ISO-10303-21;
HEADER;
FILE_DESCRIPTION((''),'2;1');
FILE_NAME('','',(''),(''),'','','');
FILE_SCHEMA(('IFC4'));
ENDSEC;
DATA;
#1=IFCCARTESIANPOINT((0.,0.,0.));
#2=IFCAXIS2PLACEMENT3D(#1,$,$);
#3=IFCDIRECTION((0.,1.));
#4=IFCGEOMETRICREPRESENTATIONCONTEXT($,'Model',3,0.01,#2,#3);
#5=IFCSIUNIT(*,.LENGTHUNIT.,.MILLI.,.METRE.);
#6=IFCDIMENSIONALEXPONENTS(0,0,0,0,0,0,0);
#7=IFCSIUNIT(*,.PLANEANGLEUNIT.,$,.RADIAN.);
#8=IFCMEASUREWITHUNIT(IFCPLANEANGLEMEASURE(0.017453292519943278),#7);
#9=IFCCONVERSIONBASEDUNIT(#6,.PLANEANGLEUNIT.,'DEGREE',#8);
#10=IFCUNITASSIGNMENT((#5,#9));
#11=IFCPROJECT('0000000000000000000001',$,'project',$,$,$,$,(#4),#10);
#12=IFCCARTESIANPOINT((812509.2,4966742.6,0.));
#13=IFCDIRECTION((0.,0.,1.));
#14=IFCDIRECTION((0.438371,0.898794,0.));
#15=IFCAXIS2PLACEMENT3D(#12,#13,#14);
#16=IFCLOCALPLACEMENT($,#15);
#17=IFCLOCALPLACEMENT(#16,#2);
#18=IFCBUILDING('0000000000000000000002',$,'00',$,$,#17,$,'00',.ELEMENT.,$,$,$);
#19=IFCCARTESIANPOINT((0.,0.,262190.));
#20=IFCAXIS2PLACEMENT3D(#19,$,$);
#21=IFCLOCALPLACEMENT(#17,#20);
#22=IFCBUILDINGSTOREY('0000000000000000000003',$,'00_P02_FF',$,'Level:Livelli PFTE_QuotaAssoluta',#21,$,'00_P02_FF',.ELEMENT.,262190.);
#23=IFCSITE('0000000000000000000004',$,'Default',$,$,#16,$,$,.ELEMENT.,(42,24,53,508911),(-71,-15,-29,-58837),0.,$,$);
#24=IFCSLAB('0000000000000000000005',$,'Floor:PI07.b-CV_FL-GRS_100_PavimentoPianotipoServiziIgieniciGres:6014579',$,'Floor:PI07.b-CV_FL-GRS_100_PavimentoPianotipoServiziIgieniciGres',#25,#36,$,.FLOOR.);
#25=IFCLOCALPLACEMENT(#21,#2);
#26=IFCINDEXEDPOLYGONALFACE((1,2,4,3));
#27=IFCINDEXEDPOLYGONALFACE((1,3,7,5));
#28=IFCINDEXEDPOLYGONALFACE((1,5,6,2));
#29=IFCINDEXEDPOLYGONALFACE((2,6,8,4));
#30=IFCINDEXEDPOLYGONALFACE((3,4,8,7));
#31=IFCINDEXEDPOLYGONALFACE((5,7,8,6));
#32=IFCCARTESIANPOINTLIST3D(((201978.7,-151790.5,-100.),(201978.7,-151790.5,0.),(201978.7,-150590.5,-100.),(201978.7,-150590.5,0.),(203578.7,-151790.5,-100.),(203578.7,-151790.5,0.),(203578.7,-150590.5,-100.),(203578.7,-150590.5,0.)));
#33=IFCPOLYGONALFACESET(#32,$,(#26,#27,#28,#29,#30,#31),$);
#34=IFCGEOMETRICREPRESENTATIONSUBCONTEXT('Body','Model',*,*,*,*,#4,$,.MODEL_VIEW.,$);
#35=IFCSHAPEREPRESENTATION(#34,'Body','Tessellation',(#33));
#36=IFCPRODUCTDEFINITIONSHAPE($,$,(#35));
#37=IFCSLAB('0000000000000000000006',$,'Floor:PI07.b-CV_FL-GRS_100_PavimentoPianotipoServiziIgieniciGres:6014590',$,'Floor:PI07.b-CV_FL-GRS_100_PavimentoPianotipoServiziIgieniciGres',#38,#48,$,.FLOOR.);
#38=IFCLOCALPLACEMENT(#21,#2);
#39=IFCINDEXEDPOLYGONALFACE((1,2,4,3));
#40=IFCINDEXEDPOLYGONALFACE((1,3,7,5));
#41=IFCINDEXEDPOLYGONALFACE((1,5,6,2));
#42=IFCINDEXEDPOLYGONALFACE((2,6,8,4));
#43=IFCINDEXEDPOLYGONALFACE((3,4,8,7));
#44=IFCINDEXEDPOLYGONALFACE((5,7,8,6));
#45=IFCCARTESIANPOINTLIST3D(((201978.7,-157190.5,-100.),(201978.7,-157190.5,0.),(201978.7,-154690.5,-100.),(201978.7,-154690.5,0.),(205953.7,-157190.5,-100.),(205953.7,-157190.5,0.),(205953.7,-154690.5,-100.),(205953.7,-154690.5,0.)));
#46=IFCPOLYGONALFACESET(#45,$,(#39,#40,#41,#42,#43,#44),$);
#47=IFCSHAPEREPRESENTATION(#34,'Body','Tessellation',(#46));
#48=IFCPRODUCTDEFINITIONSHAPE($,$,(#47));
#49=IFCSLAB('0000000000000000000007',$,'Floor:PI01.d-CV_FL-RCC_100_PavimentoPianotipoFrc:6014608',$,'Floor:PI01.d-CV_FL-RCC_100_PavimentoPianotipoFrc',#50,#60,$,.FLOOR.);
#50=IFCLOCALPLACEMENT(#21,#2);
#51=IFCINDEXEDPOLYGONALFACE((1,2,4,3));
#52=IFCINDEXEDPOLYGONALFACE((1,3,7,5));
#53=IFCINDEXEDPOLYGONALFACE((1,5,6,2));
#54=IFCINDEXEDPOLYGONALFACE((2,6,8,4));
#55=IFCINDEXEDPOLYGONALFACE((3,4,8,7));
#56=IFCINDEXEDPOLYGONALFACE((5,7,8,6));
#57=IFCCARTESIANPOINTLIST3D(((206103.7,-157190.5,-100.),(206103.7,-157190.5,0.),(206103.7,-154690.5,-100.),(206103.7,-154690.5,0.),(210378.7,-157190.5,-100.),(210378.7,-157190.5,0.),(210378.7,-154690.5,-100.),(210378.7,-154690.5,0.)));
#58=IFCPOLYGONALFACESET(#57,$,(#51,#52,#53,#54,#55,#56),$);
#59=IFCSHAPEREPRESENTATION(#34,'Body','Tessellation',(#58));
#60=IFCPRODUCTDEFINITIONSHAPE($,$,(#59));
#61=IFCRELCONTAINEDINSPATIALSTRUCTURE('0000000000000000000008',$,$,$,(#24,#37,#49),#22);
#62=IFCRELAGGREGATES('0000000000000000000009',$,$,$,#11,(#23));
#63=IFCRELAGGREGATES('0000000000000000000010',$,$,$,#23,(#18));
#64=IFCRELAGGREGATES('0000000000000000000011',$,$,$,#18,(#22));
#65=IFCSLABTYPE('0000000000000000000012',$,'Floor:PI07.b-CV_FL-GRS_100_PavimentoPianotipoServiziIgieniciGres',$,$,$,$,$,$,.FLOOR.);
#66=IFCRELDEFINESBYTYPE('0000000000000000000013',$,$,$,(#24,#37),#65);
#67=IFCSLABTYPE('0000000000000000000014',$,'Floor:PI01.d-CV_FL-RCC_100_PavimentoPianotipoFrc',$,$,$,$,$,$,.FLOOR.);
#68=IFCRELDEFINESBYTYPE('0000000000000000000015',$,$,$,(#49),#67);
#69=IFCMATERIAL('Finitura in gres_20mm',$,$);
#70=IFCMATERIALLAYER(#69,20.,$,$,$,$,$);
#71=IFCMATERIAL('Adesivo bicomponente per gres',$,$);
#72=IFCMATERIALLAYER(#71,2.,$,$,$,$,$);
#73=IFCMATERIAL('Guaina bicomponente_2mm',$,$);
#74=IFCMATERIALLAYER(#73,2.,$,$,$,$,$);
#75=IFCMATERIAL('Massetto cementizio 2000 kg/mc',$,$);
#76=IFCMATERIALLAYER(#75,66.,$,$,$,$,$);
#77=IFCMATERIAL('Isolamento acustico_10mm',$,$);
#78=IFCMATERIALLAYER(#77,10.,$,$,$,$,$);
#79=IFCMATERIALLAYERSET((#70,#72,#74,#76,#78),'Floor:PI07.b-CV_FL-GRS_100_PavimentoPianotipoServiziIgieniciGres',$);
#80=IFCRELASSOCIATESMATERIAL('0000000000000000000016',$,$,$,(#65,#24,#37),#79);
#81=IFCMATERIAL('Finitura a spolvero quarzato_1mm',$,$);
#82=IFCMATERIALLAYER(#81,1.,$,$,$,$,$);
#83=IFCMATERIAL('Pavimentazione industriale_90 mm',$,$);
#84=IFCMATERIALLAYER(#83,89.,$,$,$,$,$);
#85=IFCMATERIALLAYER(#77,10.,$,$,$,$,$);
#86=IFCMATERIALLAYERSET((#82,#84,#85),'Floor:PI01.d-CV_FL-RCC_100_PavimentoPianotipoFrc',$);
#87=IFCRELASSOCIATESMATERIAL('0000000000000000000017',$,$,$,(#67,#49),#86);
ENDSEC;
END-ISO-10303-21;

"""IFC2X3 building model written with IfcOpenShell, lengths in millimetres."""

from ifc_helpers import new_model, entity, si_unit, converted_unit, direction, frame, frame_2d, origin, origin_2d_with_axis, place, context, subcontext, project, spatial, rectangle, extrude, material, layer, layer_set, layer_usage, type_object, element, save


model = new_model("IFC2X3")

# Units and contexts
model_context = context("Model", 3, precision=0.01, world=origin(), true_north=direction((0.0, 1.0)))
body_context = subcontext(model_context, "Body", "Model", "MODEL_VIEW")
ifc_project = project(units=[si_unit("LENGTHUNIT", "METRE", prefix="MILLI"), converted_unit("PLANEANGLEUNIT", "DEGREE", entity("IfcPlaneAngleMeasure", 0.017453292519943278), si_unit("PLANEANGLEUNIT", "RADIAN"), dimensions=[0, 0, 0, 0, 0, 0, 0])], contexts=[model_context])

# Site, building, storey
site_placement = place(None, frame((812509.2, 4966742.6, 0.0), z_axis=(0.0, 0.0, 1.0), x_axis=(0.438371, 0.898794, 0.0)))
site = spatial("IfcSite", under=ifc_project, at=site_placement, Name="Default", CompositionType="ELEMENT", RefLatitude=(42, 24, 53, 508911), RefLongitude=(-71, -15, -29, -58837), RefElevation=0.0)
building_placement = place(site_placement, origin())
building = spatial("IfcBuilding", under=site, at=building_placement, Name="00", LongName="00", CompositionType="ELEMENT")
storey_placement = place(building_placement, frame((0.0, 0.0, 262190.0)))
storey = spatial("IfcBuildingStorey", under=building, at=storey_placement, Name="00_P02_FF", ObjectType="Level:Livelli PFTE_QuotaAssoluta", LongName="00_P02_FF", CompositionType="ELEMENT", Elevation=262190.0)

# Slabs
ifc_material_1 = material(Name="Massetto cementizio 2000 kg/mc")
ifc_material_2 = material(Name="Isolamento acustico_10mm")
ifc_material_3 = material(Name="Finitura in gres_20mm")
ifc_layer_1 = layer(ifc_material_3, 20.0)
ifc_material_4 = material(Name="Adesivo bicomponente per gres")
ifc_layer_2 = layer(ifc_material_4, 2.0)
ifc_material_5 = material(Name="Guaina bicomponente_2mm")
ifc_layer_3 = layer(ifc_material_5, 2.0)
ifc_layer_4 = layer(ifc_material_1, 66.0)
ifc_layer_5 = layer(ifc_material_2, 10.0)
ifc_layer_set_1 = layer_set([ifc_layer_1, ifc_layer_2, ifc_layer_3, ifc_layer_4, ifc_layer_5], Name="Floor:PI07.b-CV_FL-GRS_100_PavimentoPianotipoServiziIgieniciGres")
ifc_layer_usage_1 = layer_usage(ifc_layer_set_1, "AXIS3", "POSITIVE", 0.0)
slab_type_1 = type_object("IfcSlabType", Name="Floor:PI07.b-CV_FL-GRS_100_PavimentoPianotipoServiziIgieniciGres", PredefinedType="FLOOR", material=ifc_layer_set_1)
slab_1_placement = place(storey_placement, origin())
element("IfcSlab", 1, at=slab_1_placement, inside=storey, type_object=slab_type_1, material=ifc_layer_usage_1, Name="Floor:PI07.b-CV_FL-GRS_100_PavimentoPianotipoServiziIgieniciGres:6014579", ObjectType="Floor:PI07.b-CV_FL-GRS_100_PavimentoPianotipoServiziIgieniciGres", PredefinedType="FLOOR", context=body_context, shape_type="SweptSolid", body=[
    extrude(rectangle(XDim=1200.0, YDim=1600.0, at=origin_2d_with_axis()), frame((202778.7, -151190.5, 0.0), z_axis=(0.0, 0.0, -1.0), x_axis=(0.0, 1.0, 0.0)), (0.0, 0.0, 1.0), 100.0),
])
ifc_layer_usage_2 = layer_usage(ifc_layer_set_1, "AXIS3", "POSITIVE", 0.0)
slab_2_placement = place(storey_placement, origin())
element("IfcSlab", 2, at=slab_2_placement, inside=storey, type_object=slab_type_1, material=ifc_layer_usage_2, Name="Floor:PI07.b-CV_FL-GRS_100_PavimentoPianotipoServiziIgieniciGres:6014590", ObjectType="Floor:PI07.b-CV_FL-GRS_100_PavimentoPianotipoServiziIgieniciGres", PredefinedType="FLOOR", context=body_context, shape_type="SweptSolid", body=[
    extrude(rectangle(XDim=2500.0, YDim=3975.0, at=frame_2d((0.0, 0.0), x_axis=(1.0, 0.0))), frame((203966.2, -155940.5, 0.0), z_axis=(0.0, 0.0, -1.0), x_axis=(0.0, 1.0, 0.0)), (0.0, 0.0, 1.0), 100.0),
])
ifc_material_6 = material(Name="Finitura a spolvero quarzato_1mm")
ifc_layer_6 = layer(ifc_material_6, 1.0)
ifc_material_7 = material(Name="Pavimentazione industriale_90 mm")
ifc_layer_7 = layer(ifc_material_7, 89.0)
ifc_layer_8 = layer(ifc_material_2, 10.0)
ifc_layer_set_2 = layer_set([ifc_layer_6, ifc_layer_7, ifc_layer_8], Name="Floor:PI01.d-CV_FL-RCC_100_PavimentoPianotipoFrc")
slab_type_2 = type_object("IfcSlabType", Name="Floor:PI01.d-CV_FL-RCC_100_PavimentoPianotipoFrc", PredefinedType="FLOOR", material=ifc_layer_set_2)
ifc_layer_usage_3 = layer_usage(ifc_layer_set_2, "AXIS3", "POSITIVE", 0.0)
slab_3_placement = place(storey_placement, origin())
element("IfcSlab", 3, at=slab_3_placement, inside=storey, type_object=slab_type_2, material=ifc_layer_usage_3, Name="Floor:PI01.d-CV_FL-RCC_100_PavimentoPianotipoFrc:6014608", ObjectType="Floor:PI01.d-CV_FL-RCC_100_PavimentoPianotipoFrc", PredefinedType="FLOOR", context=body_context, shape_type="SweptSolid", body=[
    extrude(rectangle(XDim=2500.0, YDim=4275.0, at=frame_2d((0.0, 0.0), x_axis=(1.0, 0.0))), frame((208241.2, -155940.5, 0.0), z_axis=(0.0, 0.0, -1.0), x_axis=(0.0, 1.0, 0.0)), (0.0, 0.0, 1.0), 100.0),
])

save(model, "model.ifc")
